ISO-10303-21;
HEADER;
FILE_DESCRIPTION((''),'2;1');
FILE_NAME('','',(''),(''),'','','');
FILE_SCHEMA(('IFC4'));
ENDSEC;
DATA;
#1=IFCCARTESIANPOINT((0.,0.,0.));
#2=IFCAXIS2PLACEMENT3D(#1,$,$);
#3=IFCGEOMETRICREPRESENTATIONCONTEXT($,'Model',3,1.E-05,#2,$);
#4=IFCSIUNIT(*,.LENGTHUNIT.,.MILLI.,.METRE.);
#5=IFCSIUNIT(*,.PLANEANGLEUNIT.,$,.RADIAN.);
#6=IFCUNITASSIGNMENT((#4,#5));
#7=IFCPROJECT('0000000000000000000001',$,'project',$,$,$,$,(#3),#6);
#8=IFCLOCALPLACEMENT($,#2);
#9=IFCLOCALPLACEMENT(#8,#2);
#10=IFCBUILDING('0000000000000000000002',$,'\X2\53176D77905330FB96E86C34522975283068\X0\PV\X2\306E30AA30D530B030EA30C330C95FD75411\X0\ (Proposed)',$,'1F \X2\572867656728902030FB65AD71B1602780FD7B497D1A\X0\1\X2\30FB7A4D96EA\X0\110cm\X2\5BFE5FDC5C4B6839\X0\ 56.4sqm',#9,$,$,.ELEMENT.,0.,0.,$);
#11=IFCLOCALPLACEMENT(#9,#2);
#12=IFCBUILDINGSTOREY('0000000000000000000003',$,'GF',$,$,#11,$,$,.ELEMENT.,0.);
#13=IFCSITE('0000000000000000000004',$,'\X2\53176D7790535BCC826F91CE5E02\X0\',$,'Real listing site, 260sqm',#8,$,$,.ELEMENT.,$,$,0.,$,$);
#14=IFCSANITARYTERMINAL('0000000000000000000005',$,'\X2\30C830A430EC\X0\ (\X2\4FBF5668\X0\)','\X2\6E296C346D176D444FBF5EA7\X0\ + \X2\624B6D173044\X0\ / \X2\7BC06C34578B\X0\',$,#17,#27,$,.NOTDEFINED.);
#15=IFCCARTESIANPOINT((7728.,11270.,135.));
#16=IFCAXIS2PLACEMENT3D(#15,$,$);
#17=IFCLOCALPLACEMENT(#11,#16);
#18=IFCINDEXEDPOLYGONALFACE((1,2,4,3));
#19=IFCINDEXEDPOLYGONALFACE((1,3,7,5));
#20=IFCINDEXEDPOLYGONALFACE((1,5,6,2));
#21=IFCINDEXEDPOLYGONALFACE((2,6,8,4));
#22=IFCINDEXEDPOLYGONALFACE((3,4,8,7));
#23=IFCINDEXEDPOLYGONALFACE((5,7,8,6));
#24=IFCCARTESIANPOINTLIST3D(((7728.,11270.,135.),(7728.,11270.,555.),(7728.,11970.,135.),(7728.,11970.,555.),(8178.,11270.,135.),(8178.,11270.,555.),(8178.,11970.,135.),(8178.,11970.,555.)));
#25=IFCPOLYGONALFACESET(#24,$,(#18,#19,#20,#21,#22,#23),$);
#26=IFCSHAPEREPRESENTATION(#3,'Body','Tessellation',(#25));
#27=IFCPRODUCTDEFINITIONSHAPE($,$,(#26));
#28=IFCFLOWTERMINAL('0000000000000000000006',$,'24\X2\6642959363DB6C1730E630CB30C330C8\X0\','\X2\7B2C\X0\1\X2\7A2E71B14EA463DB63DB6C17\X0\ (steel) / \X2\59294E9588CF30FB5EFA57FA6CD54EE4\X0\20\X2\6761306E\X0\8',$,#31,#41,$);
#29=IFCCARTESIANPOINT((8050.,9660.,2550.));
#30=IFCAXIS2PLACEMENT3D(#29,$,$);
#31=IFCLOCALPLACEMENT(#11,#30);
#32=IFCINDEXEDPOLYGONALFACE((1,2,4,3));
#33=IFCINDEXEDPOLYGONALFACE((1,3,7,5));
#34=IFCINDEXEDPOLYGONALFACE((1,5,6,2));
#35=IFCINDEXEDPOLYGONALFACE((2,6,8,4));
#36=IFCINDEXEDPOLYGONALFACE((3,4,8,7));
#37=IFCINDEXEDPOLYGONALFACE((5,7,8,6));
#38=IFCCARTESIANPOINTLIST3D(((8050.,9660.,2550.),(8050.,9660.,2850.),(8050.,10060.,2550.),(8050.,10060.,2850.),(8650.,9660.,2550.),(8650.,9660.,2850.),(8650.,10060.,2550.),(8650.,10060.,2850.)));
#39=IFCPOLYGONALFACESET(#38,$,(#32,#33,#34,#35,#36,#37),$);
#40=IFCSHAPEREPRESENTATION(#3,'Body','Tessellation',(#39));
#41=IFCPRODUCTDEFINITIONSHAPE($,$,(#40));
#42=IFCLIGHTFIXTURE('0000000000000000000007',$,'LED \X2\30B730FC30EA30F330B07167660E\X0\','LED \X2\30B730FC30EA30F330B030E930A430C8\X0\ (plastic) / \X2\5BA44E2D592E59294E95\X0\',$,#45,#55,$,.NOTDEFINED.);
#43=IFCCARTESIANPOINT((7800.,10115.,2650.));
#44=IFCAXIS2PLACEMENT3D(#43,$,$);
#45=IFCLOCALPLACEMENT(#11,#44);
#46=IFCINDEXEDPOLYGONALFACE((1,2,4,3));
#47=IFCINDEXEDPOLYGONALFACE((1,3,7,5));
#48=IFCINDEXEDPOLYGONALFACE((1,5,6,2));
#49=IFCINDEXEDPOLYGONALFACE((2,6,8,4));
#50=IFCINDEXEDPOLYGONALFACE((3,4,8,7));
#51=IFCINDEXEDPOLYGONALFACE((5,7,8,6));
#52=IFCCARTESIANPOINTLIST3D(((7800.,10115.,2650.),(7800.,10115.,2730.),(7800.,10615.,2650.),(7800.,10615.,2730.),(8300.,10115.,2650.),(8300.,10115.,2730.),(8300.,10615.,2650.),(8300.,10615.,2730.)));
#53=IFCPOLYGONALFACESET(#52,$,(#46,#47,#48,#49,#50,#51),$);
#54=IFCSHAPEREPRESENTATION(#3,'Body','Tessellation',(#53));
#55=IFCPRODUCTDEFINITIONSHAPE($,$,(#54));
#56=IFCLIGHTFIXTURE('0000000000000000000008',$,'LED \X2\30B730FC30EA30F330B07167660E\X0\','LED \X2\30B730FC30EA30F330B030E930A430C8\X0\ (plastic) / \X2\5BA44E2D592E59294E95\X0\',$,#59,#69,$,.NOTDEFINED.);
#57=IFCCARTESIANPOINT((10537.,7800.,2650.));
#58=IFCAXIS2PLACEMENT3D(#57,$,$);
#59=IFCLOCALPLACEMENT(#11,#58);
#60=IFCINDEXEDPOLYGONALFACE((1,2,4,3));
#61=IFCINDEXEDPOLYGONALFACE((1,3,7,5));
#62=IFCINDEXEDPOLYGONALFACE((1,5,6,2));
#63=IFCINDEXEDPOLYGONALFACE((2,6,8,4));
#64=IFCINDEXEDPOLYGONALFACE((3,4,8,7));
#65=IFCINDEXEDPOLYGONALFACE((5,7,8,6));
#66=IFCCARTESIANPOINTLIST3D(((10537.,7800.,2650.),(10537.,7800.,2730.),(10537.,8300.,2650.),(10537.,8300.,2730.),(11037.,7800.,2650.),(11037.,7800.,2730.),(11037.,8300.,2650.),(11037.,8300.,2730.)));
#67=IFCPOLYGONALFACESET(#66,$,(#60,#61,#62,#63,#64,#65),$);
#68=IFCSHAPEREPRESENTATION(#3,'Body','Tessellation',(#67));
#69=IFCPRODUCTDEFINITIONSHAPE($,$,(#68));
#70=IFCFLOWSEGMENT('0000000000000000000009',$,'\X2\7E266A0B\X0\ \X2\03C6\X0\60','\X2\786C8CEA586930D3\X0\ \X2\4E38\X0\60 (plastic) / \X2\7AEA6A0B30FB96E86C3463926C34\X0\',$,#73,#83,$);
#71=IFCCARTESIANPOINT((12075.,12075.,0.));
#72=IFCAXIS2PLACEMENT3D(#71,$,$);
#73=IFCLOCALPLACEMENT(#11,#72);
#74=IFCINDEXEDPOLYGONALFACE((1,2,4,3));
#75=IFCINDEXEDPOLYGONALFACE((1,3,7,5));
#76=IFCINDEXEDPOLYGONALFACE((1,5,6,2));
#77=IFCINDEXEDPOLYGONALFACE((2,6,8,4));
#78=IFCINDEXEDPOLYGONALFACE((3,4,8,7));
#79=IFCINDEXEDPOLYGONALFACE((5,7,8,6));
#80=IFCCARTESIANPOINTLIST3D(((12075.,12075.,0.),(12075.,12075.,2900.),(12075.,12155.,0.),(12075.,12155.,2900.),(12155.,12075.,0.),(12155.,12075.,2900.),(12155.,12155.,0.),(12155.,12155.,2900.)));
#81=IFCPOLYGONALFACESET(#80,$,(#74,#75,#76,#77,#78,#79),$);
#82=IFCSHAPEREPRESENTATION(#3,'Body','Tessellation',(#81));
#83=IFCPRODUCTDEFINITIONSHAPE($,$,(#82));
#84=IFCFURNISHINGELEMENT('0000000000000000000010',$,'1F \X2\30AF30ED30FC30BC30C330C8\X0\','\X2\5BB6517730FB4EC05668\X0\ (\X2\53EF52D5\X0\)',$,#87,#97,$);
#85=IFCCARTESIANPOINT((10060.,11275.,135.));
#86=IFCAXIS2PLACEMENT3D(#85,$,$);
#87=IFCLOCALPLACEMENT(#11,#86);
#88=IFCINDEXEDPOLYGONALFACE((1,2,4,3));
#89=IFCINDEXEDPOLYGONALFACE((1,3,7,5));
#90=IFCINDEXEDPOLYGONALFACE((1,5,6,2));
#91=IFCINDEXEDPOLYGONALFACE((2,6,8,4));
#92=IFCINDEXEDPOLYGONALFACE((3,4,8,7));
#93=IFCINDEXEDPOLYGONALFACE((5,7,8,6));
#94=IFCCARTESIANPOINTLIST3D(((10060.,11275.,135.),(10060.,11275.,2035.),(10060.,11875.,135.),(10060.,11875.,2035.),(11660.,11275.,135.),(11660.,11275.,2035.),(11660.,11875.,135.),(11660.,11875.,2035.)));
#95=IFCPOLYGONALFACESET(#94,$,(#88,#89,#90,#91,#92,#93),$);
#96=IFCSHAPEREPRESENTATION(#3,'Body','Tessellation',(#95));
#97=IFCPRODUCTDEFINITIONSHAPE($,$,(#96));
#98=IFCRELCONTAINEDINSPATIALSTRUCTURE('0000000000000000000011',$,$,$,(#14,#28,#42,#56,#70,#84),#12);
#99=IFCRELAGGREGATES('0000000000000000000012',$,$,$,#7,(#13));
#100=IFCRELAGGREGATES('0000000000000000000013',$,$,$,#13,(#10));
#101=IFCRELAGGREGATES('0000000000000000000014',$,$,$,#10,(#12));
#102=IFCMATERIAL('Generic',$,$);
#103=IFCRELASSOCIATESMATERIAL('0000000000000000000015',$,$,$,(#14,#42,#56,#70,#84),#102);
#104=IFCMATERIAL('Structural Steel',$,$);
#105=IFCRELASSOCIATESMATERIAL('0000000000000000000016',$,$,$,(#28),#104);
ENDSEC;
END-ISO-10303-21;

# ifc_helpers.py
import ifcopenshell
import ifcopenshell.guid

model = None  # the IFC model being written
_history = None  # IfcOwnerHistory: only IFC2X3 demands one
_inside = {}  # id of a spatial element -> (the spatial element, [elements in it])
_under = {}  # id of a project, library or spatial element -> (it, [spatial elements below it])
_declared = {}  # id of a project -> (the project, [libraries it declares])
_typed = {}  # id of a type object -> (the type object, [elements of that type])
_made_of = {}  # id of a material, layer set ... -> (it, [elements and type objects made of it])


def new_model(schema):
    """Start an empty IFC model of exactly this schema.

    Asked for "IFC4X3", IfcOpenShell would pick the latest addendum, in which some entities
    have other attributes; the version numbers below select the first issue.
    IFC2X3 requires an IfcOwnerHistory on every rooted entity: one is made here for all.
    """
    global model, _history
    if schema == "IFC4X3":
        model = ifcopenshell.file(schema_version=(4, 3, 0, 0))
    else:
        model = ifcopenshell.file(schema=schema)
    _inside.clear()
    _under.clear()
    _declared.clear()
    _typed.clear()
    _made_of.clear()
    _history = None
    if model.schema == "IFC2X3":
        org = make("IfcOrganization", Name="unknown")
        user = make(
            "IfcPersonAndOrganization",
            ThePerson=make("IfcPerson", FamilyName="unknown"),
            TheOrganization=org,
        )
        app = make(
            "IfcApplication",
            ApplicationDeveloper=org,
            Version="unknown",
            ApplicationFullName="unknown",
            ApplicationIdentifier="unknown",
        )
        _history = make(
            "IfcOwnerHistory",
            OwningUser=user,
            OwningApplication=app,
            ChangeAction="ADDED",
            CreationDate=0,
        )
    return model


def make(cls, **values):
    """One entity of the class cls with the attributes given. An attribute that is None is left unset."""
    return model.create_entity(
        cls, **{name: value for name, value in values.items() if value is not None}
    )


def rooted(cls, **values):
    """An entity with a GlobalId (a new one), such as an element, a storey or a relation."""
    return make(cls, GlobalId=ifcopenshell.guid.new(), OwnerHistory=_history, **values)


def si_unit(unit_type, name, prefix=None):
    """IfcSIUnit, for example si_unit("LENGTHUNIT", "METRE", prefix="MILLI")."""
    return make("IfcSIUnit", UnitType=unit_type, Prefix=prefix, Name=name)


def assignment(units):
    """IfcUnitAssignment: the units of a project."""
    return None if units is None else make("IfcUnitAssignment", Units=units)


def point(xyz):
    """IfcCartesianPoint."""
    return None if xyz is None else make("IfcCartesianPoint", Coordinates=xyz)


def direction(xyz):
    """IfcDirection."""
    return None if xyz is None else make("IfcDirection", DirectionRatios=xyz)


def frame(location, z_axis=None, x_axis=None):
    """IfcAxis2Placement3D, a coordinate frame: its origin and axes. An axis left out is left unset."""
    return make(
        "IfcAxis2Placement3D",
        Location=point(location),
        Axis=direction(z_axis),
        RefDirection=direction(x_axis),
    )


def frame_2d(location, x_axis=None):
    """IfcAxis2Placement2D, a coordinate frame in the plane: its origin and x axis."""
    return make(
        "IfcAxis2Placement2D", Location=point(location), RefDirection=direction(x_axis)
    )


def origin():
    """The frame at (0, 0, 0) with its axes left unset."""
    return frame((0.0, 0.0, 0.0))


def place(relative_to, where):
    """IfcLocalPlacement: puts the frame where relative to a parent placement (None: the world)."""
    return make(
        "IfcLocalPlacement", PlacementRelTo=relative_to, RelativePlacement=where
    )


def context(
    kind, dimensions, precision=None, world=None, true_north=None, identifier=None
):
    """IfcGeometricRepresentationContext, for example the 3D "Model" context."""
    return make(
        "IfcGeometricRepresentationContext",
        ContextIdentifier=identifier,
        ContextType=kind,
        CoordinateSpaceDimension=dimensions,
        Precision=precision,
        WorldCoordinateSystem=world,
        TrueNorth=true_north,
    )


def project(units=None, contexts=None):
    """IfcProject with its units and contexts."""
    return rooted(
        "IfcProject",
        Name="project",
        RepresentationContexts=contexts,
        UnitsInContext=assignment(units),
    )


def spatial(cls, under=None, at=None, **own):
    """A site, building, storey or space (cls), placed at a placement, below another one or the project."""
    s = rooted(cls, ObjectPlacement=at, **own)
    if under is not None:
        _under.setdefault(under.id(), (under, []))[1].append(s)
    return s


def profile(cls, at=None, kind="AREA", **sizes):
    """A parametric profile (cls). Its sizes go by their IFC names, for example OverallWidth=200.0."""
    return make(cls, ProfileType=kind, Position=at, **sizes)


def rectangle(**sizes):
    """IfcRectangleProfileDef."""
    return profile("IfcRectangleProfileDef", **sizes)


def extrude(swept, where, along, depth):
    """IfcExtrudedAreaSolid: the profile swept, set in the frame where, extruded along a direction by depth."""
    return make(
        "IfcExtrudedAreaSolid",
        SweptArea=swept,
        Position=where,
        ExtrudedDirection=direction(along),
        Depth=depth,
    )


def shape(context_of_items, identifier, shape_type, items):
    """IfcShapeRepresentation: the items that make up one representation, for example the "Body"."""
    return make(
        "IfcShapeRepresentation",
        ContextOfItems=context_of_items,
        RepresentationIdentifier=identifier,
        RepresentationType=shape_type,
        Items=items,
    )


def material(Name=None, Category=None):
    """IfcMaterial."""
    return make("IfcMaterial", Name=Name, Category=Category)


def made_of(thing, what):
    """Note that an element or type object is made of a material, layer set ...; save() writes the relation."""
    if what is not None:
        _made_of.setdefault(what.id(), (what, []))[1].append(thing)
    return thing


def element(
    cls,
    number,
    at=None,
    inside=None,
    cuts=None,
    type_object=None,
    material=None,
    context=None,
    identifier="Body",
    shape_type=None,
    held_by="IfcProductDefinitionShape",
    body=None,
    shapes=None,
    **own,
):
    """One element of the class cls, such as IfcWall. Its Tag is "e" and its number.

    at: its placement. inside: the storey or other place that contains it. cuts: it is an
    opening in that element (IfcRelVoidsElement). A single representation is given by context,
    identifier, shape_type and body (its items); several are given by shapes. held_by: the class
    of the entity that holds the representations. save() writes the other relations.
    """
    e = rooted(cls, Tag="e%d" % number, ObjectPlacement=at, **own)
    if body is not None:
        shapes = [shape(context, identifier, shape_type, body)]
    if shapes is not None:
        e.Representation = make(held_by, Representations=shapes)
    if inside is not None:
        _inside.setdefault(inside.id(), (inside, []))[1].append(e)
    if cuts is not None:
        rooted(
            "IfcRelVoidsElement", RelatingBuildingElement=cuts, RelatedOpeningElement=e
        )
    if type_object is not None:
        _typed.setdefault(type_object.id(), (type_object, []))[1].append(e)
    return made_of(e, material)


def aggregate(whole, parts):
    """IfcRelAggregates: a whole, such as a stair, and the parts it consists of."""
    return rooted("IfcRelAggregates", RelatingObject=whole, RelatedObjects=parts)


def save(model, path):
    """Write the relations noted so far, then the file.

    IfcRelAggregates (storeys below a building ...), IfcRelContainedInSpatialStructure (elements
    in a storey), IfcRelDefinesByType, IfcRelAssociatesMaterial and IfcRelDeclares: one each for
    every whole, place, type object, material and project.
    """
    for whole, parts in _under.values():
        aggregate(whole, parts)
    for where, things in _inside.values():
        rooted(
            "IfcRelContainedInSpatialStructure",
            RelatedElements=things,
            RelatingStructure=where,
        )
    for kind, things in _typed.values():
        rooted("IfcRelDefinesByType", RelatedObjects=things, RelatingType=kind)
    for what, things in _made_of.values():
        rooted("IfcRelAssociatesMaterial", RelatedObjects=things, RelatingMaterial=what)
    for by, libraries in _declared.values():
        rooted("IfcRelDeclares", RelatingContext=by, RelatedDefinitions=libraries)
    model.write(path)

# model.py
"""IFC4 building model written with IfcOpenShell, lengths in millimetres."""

from ifc_helpers import new_model, si_unit, frame, frame_2d, origin, place, context, project, spatial, rectangle, extrude, material, element, save


model = new_model("IFC4")

# Units and contexts
model_context = context("Model", 3, precision=1e-05, world=origin())
ifc_project = project(units=[si_unit("LENGTHUNIT", "METRE", prefix="MILLI"), si_unit("PLANEANGLEUNIT", "RADIAN")], contexts=[model_context])

# Site, building, storey
site_placement = place(None, origin())
site = spatial("IfcSite", under=ifc_project, at=site_placement, Name="北海道富良野市", ObjectType="Real listing site, 260sqm", CompositionType="ELEMENT", RefElevation=0.0)
building_placement = place(site_placement, origin())
building = spatial("IfcBuilding", under=site, at=building_placement, Name="北海道・雨水利用とPVのオフグリッド志向 (Proposed)", ObjectType="1F 在来木造・断熱性能等級1・積雪110cm対応屋根 56.4sqm", CompositionType="ELEMENT", ElevationOfRefHeight=0.0, ElevationOfTerrain=0.0)
storey_placement = place(building_placement, origin())
storey = spatial("IfcBuildingStorey", under=building, at=storey_placement, Name="GF", CompositionType="ELEMENT", Elevation=0.0)

# Shared definitions
ifc_material_1 = material(Name="Generic")

# Sanitary terminal
sanitary_terminal_placement = place(storey_placement, frame((7728.0, 11270.0, 135.0)))
element("IfcSanitaryTerminal", 1, at=sanitary_terminal_placement, inside=storey, material=ifc_material_1, Name="トイレ (便器)", Description="温水洗浄便座 + 手洗い / 節水型", PredefinedType="NOTDEFINED", context=model_context, shape_type="SweptSolid", body=[
    extrude(rectangle(XDim=450.0, YDim=700.0, at=frame_2d((225.0, 350.0))), frame((7728.0, 11270.0, 135.0)), (0.0, 0.0, 1.0), 420.0),
])

# Flow terminal
ifc_material_2 = material(Name="Structural Steel")
flow_terminal_placement = place(storey_placement, frame((8050.0, 9660.0, 2550.0)))
element("IfcFlowTerminal", 2, at=flow_terminal_placement, inside=storey, material=ifc_material_2, Name="24時間換気ユニット", Description="第1種熱交換換気 (steel) / 天井裏・建基法令20条の8", context=model_context, shape_type="SweptSolid", body=[
    extrude(rectangle(XDim=600.0, YDim=400.0, at=frame_2d((300.0, 200.0))), frame((8050.0, 9660.0, 2550.0)), (0.0, 0.0, 1.0), 300.0),
])

# Light fixtures
light_fixture_1_placement = place(storey_placement, frame((7800.0, 10115.0, 2650.0)))
element("IfcLightFixture", 3, at=light_fixture_1_placement, inside=storey, material=ifc_material_1, Name="LED シーリング照明", Description="LED シーリングライト (plastic) / 室中央天井", PredefinedType="NOTDEFINED", context=model_context, shape_type="SweptSolid", body=[
    extrude(rectangle(XDim=500.0, YDim=500.0, at=frame_2d((250.0, 250.0))), frame((7800.0, 10115.0, 2650.0)), (0.0, 0.0, 1.0), 80.0),
])
light_fixture_2_placement = place(storey_placement, frame((10537.0, 7800.0, 2650.0)))
element("IfcLightFixture", 4, at=light_fixture_2_placement, inside=storey, material=ifc_material_1, Name="LED シーリング照明", Description="LED シーリングライト (plastic) / 室中央天井", PredefinedType="NOTDEFINED", context=model_context, shape_type="SweptSolid", body=[
    extrude(rectangle(XDim=500.0, YDim=500.0, at=frame_2d((250.0, 250.0))), frame((10537.0, 7800.0, 2650.0)), (0.0, 0.0, 1.0), 80.0),
])

# Flow segment
flow_segment_placement = place(storey_placement, frame((12075.0, 12075.0, 0.0)))
element("IfcFlowSegment", 5, at=flow_segment_placement, inside=storey, material=ifc_material_1, Name="縦樋 φ60", Description="硬質塩ビ 丸60 (plastic) / 竪樋・雨水排水", context=model_context, shape_type="SweptSolid", body=[
    extrude(rectangle(XDim=80.0, YDim=80.0, at=frame_2d((40.0, 40.0))), frame((12075.0, 12075.0, 0.0)), (0.0, 0.0, 1.0), 2900.0),
])

# Furnishing element
furnishing_placement = place(storey_placement, frame((10060.0, 11275.0, 135.0)))
element("IfcFurnishingElement", 6, at=furnishing_placement, inside=storey, material=ifc_material_1, Name="1F クローゼット", Description="家具・什器 (可動)", context=model_context, shape_type="SweptSolid", body=[
    extrude(rectangle(XDim=1600.0, YDim=600.0, at=frame_2d((800.0, 300.0))), frame((10060.0, 11275.0, 135.0)), (0.0, 0.0, 1.0), 1900.0),
])

save(model, "model.ifc")
